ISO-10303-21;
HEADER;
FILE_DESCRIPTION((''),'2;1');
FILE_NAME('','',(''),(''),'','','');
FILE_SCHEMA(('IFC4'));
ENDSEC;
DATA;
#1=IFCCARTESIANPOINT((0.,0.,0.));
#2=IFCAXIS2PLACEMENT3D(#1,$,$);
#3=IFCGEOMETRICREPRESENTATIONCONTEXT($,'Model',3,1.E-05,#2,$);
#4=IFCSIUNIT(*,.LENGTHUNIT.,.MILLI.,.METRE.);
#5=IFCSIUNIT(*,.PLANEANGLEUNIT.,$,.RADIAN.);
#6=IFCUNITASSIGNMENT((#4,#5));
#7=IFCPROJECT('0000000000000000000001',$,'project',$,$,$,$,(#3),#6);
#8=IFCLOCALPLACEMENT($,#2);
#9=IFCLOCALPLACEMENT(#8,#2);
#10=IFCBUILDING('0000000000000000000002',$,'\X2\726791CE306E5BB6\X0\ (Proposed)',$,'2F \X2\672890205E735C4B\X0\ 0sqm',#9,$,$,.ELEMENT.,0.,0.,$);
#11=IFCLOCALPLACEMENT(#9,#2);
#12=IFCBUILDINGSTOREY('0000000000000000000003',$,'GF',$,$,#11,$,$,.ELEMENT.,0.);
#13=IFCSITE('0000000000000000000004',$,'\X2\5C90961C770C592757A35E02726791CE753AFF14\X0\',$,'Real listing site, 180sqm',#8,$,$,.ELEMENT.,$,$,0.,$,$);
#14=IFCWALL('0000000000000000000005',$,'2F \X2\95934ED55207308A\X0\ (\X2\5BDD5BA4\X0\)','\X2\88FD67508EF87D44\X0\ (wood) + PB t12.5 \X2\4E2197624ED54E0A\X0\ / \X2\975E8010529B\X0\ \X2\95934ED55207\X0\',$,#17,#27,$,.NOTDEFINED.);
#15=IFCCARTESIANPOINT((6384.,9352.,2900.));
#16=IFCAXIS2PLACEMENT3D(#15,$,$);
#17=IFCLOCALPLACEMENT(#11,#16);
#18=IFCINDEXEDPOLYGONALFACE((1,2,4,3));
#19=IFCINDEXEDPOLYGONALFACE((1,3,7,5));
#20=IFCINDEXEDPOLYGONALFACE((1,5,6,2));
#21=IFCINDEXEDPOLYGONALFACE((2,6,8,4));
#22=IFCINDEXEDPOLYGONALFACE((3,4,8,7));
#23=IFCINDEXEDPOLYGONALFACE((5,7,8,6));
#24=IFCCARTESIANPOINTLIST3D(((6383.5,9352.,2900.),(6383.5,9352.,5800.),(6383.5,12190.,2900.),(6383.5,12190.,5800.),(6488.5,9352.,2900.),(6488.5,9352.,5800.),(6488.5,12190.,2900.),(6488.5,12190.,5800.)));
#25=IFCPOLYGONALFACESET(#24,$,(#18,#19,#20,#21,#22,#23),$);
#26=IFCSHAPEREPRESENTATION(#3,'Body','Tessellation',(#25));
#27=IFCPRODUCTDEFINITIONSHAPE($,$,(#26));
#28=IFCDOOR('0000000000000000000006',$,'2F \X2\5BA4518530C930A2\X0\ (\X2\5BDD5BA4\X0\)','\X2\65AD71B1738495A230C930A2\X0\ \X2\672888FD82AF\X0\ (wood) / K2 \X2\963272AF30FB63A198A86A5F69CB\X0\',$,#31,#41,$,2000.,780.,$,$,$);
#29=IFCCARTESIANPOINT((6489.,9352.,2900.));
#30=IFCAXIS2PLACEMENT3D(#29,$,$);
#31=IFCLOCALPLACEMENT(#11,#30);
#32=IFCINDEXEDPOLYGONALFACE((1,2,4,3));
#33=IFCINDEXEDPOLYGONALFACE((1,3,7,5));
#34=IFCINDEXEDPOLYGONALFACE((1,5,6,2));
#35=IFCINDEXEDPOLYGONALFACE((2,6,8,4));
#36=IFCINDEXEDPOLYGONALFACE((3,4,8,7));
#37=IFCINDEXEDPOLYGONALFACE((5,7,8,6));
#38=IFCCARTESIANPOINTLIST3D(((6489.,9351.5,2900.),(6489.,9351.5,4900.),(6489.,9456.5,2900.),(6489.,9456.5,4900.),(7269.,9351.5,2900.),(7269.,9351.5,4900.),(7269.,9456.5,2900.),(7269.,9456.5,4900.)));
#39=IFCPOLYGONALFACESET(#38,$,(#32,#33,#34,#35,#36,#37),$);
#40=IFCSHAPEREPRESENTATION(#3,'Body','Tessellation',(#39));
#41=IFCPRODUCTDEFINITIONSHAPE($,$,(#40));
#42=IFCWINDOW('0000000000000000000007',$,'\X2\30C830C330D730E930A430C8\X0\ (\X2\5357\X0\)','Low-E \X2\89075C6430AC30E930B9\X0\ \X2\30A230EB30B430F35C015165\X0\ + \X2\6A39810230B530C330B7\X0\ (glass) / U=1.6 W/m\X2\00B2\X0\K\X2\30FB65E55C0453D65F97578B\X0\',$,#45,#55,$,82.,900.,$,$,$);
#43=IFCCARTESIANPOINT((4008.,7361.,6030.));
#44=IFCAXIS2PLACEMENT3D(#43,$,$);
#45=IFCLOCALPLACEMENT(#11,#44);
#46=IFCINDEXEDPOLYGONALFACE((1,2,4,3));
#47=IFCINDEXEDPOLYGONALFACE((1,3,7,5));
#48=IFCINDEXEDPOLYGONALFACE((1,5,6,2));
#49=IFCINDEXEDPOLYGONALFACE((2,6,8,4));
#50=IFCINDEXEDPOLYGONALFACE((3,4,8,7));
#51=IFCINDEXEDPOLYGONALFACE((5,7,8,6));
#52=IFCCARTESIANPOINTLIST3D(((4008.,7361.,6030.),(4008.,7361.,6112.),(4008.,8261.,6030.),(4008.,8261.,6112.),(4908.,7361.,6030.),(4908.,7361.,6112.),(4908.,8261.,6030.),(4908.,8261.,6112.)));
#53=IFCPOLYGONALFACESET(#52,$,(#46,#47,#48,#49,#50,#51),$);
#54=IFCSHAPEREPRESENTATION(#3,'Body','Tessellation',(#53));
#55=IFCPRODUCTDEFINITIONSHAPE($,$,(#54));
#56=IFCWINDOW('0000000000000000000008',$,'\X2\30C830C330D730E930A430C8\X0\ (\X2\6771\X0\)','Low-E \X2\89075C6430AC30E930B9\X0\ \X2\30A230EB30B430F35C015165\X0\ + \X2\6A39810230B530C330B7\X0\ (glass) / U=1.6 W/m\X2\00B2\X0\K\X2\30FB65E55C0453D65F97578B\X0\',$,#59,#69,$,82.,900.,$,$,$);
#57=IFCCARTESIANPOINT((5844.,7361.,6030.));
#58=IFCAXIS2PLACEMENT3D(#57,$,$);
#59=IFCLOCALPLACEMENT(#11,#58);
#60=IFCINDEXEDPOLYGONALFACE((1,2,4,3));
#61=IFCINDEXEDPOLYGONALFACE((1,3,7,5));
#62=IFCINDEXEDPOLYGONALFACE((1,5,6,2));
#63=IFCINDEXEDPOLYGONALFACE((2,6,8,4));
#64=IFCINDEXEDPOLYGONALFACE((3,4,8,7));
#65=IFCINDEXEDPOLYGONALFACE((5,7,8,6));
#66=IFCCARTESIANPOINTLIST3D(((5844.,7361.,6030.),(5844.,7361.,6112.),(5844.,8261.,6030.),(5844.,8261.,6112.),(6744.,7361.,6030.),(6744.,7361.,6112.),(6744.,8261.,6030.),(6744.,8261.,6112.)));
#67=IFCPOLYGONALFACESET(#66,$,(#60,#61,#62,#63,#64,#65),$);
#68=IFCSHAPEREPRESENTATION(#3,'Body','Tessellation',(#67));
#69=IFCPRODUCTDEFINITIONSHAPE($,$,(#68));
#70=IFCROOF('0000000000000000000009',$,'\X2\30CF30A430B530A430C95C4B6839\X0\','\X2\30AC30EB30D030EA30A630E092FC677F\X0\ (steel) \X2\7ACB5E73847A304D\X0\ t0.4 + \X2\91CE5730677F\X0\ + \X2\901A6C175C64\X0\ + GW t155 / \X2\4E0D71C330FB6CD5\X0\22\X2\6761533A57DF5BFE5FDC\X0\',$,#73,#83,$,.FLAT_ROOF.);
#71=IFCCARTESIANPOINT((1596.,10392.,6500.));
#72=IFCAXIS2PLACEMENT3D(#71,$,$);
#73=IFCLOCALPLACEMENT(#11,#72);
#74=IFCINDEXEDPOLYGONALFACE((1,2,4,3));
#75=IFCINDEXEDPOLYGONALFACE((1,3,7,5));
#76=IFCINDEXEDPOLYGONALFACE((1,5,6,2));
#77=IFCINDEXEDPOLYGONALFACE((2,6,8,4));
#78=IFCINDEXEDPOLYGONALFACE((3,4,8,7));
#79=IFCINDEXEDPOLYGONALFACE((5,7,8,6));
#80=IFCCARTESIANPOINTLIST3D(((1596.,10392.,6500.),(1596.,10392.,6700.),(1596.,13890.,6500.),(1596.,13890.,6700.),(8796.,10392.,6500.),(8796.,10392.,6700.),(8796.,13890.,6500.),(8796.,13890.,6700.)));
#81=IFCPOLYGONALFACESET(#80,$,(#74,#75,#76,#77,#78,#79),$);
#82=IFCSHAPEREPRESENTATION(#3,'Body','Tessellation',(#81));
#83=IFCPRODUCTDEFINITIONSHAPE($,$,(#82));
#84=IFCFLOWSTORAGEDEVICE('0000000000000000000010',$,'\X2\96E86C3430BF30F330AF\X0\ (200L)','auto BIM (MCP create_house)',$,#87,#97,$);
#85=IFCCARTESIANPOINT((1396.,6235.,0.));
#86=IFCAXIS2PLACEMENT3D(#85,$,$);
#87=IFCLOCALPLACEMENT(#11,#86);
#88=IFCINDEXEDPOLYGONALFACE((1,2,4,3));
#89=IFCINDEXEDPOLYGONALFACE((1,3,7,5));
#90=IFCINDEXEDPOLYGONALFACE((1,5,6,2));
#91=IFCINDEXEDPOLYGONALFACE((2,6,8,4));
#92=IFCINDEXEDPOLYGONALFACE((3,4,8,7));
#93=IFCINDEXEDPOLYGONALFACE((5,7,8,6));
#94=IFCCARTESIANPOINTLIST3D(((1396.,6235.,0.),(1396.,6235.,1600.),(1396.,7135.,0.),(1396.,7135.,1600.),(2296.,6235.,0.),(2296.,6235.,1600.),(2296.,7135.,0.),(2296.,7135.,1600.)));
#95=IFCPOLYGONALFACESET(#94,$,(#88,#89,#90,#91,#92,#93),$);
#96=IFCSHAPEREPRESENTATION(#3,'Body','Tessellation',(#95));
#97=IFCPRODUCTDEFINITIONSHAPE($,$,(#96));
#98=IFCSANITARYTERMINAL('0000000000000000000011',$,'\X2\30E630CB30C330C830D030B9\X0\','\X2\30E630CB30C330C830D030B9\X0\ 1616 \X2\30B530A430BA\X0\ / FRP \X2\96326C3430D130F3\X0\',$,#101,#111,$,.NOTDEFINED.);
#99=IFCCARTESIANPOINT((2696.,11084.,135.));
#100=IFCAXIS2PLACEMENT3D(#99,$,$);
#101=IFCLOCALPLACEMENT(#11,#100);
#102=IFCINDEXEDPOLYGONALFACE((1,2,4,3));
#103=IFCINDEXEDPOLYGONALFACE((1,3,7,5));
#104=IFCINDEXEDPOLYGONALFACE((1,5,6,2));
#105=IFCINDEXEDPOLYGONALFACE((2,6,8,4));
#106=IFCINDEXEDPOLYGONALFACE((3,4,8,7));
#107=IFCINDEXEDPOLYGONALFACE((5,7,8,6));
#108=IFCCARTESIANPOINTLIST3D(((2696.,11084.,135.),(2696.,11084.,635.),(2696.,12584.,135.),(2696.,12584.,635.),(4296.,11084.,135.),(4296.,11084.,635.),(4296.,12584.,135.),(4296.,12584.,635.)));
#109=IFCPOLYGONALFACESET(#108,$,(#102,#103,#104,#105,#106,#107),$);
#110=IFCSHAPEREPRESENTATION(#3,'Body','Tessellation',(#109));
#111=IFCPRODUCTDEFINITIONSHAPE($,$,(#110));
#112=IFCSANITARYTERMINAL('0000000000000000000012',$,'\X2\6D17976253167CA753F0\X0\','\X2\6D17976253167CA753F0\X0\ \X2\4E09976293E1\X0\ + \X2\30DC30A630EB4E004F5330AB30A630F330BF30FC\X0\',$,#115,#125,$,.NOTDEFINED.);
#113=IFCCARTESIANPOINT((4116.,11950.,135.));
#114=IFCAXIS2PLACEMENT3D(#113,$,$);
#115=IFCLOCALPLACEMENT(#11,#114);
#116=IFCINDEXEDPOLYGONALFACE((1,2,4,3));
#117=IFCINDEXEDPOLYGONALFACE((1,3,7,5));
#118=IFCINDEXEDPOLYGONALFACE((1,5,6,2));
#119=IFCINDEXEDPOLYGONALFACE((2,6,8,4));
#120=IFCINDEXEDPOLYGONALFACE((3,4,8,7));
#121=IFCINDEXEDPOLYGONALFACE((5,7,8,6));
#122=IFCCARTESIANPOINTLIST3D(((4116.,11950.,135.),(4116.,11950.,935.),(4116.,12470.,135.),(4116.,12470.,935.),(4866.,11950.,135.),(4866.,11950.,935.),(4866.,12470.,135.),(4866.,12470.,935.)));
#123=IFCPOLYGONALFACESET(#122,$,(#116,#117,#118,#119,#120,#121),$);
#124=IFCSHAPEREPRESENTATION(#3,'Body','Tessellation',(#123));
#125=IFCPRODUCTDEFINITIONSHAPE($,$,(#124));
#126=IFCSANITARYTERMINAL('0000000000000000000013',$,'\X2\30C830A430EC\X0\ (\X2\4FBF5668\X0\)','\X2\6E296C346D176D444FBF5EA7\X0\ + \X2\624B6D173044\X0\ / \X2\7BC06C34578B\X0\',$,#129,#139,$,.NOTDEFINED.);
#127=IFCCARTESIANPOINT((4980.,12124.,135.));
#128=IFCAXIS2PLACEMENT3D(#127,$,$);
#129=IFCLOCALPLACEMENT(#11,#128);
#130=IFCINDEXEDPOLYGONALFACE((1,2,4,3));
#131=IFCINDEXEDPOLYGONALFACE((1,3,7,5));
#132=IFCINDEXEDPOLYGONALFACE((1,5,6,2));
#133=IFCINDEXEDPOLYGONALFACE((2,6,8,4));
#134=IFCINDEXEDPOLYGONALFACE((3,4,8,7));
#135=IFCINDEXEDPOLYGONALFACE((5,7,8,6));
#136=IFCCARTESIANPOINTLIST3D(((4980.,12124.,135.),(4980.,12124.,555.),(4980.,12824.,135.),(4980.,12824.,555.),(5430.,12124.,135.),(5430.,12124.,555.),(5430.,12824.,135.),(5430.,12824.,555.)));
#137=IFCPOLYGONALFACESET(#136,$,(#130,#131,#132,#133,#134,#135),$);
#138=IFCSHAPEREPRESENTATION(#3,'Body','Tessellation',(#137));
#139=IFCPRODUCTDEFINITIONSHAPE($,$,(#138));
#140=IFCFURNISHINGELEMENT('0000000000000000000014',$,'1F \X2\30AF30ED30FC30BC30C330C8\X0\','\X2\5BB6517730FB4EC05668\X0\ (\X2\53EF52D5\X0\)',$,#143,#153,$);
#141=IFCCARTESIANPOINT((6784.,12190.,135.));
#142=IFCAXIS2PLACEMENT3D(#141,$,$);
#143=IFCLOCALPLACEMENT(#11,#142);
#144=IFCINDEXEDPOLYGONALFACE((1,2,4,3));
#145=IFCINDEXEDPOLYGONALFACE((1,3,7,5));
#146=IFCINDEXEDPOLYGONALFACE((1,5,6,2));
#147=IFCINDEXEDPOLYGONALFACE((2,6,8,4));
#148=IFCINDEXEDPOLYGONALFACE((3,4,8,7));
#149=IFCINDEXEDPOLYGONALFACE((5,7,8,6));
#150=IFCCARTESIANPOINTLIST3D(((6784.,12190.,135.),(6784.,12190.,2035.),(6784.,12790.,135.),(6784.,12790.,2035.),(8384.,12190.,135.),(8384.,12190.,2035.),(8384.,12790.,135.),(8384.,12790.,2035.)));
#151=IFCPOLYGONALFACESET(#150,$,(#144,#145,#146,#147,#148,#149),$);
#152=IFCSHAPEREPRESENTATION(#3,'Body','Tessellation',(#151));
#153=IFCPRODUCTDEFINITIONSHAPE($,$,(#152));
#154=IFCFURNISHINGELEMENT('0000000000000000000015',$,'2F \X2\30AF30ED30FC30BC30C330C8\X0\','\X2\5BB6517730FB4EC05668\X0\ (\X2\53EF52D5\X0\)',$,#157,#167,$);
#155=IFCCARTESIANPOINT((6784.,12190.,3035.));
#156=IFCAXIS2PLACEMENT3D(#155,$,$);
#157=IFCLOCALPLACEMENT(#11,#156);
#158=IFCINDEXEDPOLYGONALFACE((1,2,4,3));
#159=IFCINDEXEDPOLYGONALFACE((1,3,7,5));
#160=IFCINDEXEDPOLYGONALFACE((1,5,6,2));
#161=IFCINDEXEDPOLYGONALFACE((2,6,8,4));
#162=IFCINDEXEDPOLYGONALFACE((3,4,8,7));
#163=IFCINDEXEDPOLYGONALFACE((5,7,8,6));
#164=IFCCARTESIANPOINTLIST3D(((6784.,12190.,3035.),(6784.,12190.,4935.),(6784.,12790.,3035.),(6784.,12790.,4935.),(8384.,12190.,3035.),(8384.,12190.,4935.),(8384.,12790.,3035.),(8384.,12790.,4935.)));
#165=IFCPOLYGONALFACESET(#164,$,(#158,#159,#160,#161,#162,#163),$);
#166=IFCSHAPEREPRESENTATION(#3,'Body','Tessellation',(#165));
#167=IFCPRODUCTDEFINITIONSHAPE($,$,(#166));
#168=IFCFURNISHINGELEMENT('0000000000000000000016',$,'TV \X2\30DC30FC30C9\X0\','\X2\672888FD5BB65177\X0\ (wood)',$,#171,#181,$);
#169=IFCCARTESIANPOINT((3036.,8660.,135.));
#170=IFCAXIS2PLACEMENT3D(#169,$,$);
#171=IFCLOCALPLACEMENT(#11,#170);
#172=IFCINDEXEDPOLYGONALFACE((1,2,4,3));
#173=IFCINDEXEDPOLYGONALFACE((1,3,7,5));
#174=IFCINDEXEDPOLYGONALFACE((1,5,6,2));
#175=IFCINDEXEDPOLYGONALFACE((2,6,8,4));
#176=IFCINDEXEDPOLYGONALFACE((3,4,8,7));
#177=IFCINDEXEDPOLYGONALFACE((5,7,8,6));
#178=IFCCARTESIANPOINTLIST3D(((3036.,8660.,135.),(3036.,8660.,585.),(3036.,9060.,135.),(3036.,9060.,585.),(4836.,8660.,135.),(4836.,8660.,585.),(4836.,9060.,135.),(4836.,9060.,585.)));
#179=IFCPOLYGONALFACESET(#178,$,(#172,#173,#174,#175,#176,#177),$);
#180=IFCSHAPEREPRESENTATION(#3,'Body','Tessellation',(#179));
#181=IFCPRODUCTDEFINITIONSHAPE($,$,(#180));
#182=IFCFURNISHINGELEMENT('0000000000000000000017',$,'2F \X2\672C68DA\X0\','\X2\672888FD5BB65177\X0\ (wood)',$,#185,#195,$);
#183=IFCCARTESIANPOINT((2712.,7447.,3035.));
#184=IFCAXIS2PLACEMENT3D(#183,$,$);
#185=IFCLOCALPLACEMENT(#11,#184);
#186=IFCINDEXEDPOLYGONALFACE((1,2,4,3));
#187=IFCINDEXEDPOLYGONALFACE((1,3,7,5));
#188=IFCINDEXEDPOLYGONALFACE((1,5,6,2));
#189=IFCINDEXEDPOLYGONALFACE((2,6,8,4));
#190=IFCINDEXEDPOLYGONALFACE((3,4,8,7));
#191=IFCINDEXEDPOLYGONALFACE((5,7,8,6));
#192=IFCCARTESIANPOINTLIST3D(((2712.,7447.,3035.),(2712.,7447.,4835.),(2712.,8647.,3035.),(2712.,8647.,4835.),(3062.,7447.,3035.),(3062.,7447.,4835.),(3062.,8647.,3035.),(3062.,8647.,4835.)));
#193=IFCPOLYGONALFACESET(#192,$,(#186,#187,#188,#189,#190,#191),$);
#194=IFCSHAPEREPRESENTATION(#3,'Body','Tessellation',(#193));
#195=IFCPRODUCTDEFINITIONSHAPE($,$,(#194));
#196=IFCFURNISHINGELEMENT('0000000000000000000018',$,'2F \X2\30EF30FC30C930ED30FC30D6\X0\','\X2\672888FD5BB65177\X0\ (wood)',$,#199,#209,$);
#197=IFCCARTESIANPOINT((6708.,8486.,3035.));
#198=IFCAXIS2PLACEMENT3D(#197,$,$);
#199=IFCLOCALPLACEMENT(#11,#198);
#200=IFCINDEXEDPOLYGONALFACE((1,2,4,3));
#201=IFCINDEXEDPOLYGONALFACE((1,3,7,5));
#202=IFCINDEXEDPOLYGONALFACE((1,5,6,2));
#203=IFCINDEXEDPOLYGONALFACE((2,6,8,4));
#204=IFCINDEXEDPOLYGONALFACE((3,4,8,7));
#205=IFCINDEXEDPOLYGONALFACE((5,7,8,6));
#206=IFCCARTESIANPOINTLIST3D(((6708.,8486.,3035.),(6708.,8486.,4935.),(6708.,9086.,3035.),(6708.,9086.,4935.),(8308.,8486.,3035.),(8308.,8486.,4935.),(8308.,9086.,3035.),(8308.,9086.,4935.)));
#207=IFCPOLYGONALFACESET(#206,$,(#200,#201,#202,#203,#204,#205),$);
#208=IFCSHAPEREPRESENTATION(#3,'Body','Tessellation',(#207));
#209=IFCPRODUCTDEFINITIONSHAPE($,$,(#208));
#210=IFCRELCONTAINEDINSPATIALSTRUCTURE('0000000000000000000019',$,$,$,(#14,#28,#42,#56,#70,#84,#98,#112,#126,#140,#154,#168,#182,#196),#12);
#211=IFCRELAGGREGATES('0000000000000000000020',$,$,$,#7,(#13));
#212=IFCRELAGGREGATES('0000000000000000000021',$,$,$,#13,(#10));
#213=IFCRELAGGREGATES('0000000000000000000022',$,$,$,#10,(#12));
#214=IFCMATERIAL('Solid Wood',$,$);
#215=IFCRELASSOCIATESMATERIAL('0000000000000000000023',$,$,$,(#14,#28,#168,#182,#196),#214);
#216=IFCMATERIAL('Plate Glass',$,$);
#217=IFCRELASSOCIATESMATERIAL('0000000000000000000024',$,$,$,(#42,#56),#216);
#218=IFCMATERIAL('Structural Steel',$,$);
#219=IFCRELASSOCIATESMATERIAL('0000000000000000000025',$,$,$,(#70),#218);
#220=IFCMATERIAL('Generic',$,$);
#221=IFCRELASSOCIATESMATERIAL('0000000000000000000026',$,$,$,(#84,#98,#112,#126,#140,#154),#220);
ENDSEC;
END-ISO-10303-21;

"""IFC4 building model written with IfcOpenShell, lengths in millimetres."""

from ifc_helpers import new_model, si_unit, frame, frame_2d, origin, place, context, project, spatial, rectangle, extrude, material, element, save


model = new_model("IFC4")

# Units and contexts
model_context = context("Model", 3, precision=1e-05, world=origin())
ifc_project = project(units=[si_unit("LENGTHUNIT", "METRE", prefix="MILLI"), si_unit("PLANEANGLEUNIT", "RADIAN")], contexts=[model_context])

# Site, building, storey
site_placement = place(None, origin())
site = spatial("IfcSite", under=ifc_project, at=site_placement, Name="岐阜県大垣市牧野町４", ObjectType="Real listing site, 180sqm", CompositionType="ELEMENT", RefElevation=0.0)
building_placement = place(site_placement, origin())
building = spatial("IfcBuilding", under=site, at=building_placement, Name="牧野の家 (Proposed)", ObjectType="2F 木造平屋 0sqm", CompositionType="ELEMENT", ElevationOfRefHeight=0.0, ElevationOfTerrain=0.0)
storey_placement = place(building_placement, origin())
storey = spatial("IfcBuildingStorey", under=building, at=storey_placement, Name="GF", CompositionType="ELEMENT", Elevation=0.0)

# Shared definitions
ifc_material_1 = material(Name="Solid Wood")
ifc_material_2 = material(Name="Plate Glass")

# Wall
wall_1_placement = place(storey_placement, frame((6384.0, 9352.0, 2900.0)))
element("IfcWall", 1, at=wall_1_placement, inside=storey, material=ifc_material_1, Name="2F 間仕切り (寝室)", Description="製材軸組 (wood) + PB t12.5 両面仕上 / 非耐力 間仕切", PredefinedType="NOTDEFINED", context=model_context, shape_type="SweptSolid", body=[
    extrude(rectangle(XDim=105.0, YDim=2838.0, at=frame_2d((52.0, 1419.0))), frame((6384.0, 9352.0, 2900.0)), (0.0, 0.0, 1.0), 2900.0),
])

# Door
door_1_placement = place(storey_placement, frame((6489.0, 9352.0, 2900.0)))
element("IfcDoor", 2, at=door_1_placement, inside=storey, material=ifc_material_1, Name="2F 室内ドア (寝室)", Description="断熱玄関ドア 木製芯 (wood) / K2 防犯・採風機構", OverallHeight=2000.0, OverallWidth=780.0, context=model_context, shape_type="SweptSolid", body=[
    extrude(rectangle(XDim=780.0, YDim=105.0, at=frame_2d((390.0, 52.0))), frame((6489.0, 9352.0, 2900.0)), (0.0, 0.0, 1.0), 2000.0),
])

# Windows
window_1_placement = place(storey_placement, frame((4008.0, 7361.0, 6030.0)))
element("IfcWindow", 3, at=window_1_placement, inside=storey, material=ifc_material_2, Name="トップライト (南)", Description="Low-E 複層ガラス アルゴン封入 + 樹脂サッシ (glass) / U=1.6 W/m²K・日射取得型", OverallHeight=82.0, OverallWidth=900.0, context=model_context, shape_type="SweptSolid", body=[
    extrude(rectangle(XDim=900.0, YDim=900.0, at=frame_2d((450.0, 450.0))), frame((4008.0, 7361.0, 6030.0)), (0.0, 0.0, 1.0), 82.0),
])
window_2_placement = place(storey_placement, frame((5844.0, 7361.0, 6030.0)))
element("IfcWindow", 4, at=window_2_placement, inside=storey, material=ifc_material_2, Name="トップライト (東)", Description="Low-E 複層ガラス アルゴン封入 + 樹脂サッシ (glass) / U=1.6 W/m²K・日射取得型", OverallHeight=82.0, OverallWidth=900.0, context=model_context, shape_type="SweptSolid", body=[
    extrude(rectangle(XDim=900.0, YDim=900.0, at=frame_2d((450.0, 450.0))), frame((5844.0, 7361.0, 6030.0)), (0.0, 0.0, 1.0), 82.0),
])

# Roof
ifc_material_3 = material(Name="Structural Steel")
roof_placement = place(storey_placement, frame((1596.0, 10392.0, 6500.0)))
element("IfcRoof", 5, at=roof_placement, inside=storey, material=ifc_material_3, Name="ハイサイド屋根", Description="ガルバリウム鋼板 (steel) 立平葺き t0.4 + 野地板 + 通気層 + GW t155 / 不燃・法22条区域対応", PredefinedType="FLAT_ROOF", context=model_context, shape_type="SweptSolid", body=[
    extrude(rectangle(XDim=7200.0, YDim=3498.0, at=frame_2d((3600.0, 1749.0))), frame((1596.0, 10392.0, 6500.0)), (0.0, 0.0, 1.0), 200.0),
])

# Flow storage device
ifc_material_4 = material(Name="Generic")
flow_storage_device_placement = place(storey_placement, frame((1396.0, 6235.0, 0.0)))
element("IfcFlowStorageDevice", 6, at=flow_storage_device_placement, inside=storey, material=ifc_material_4, Name="雨水タンク (200L)", Description="auto BIM (MCP create_house)", context=model_context, shape_type="SweptSolid", body=[
    extrude(rectangle(XDim=900.0, YDim=900.0, at=frame_2d((450.0, 450.0))), frame((1396.0, 6235.0, 0.0)), (0.0, 0.0, 1.0), 1600.0),
])

# Sanitary terminals
sanitary_terminal_1_placement = place(storey_placement, frame((2696.0, 11084.0, 135.0)))
element("IfcSanitaryTerminal", 7, at=sanitary_terminal_1_placement, inside=storey, material=ifc_material_4, Name="ユニットバス", Description="ユニットバス 1616 サイズ / FRP 防水パン", PredefinedType="NOTDEFINED", context=model_context, shape_type="SweptSolid", body=[
    extrude(rectangle(XDim=1600.0, YDim=1500.0, at=frame_2d((800.0, 750.0))), frame((2696.0, 11084.0, 135.0)), (0.0, 0.0, 1.0), 500.0),
])
sanitary_terminal_2_placement = place(storey_placement, frame((4116.0, 11950.0, 135.0)))
element("IfcSanitaryTerminal", 8, at=sanitary_terminal_2_placement, inside=storey, material=ifc_material_4, Name="洗面化粧台", Description="洗面化粧台 三面鏡 + ボウル一体カウンター", PredefinedType="NOTDEFINED", context=model_context, shape_type="SweptSolid", body=[
    extrude(rectangle(XDim=750.0, YDim=520.0, at=frame_2d((375.0, 260.0))), frame((4116.0, 11950.0, 135.0)), (0.0, 0.0, 1.0), 800.0),
])
sanitary_terminal_3_placement = place(storey_placement, frame((4980.0, 12124.0, 135.0)))
element("IfcSanitaryTerminal", 9, at=sanitary_terminal_3_placement, inside=storey, material=ifc_material_4, Name="トイレ (便器)", Description="温水洗浄便座 + 手洗い / 節水型", PredefinedType="NOTDEFINED", context=model_context, shape_type="SweptSolid", body=[
    extrude(rectangle(XDim=450.0, YDim=700.0, at=frame_2d((225.0, 350.0))), frame((4980.0, 12124.0, 135.0)), (0.0, 0.0, 1.0), 420.0),
])

# Furnishing elements
furnishing_1_placement = place(storey_placement, frame((6784.0, 12190.0, 135.0)))
element("IfcFurnishingElement", 10, at=furnishing_1_placement, inside=storey, material=ifc_material_4, Name="1F クローゼット", Description="家具・什器 (可動)", context=model_context, shape_type="SweptSolid", body=[
    extrude(rectangle(XDim=1600.0, YDim=600.0, at=frame_2d((800.0, 300.0))), frame((6784.0, 12190.0, 135.0)), (0.0, 0.0, 1.0), 1900.0),
])
furnishing_2_placement = place(storey_placement, frame((6784.0, 12190.0, 3035.0)))
element("IfcFurnishingElement", 11, at=furnishing_2_placement, inside=storey, material=ifc_material_4, Name="2F クローゼット", Description="家具・什器 (可動)", context=model_context, shape_type="SweptSolid", body=[
    extrude(rectangle(XDim=1600.0, YDim=600.0, at=frame_2d((800.0, 300.0))), frame((6784.0, 12190.0, 3035.0)), (0.0, 0.0, 1.0), 1900.0),
])
furnishing_3_placement = place(storey_placement, frame((3036.0, 8660.0, 135.0)))
element("IfcFurnishingElement", 12, at=furnishing_3_placement, inside=storey, material=ifc_material_1, Name="TV ボード", Description="木製家具 (wood)", context=model_context, shape_type="SweptSolid", body=[
    extrude(rectangle(XDim=1800.0, YDim=400.0, at=frame_2d((900.0, 200.0))), frame((3036.0, 8660.0, 135.0)), (0.0, 0.0, 1.0), 450.0),
])
furnishing_4_placement = place(storey_placement, frame((2712.0, 7447.0, 3035.0)))
element("IfcFurnishingElement", 13, at=furnishing_4_placement, inside=storey, material=ifc_material_1, Name="2F 本棚", Description="木製家具 (wood)", context=model_context, shape_type="SweptSolid", body=[
    extrude(rectangle(XDim=350.0, YDim=1200.0, at=frame_2d((175.0, 600.0))), frame((2712.0, 7447.0, 3035.0)), (0.0, 0.0, 1.0), 1800.0),
])
furnishing_5_placement = place(storey_placement, frame((6708.0, 8486.0, 3035.0)))
element("IfcFurnishingElement", 14, at=furnishing_5_placement, inside=storey, material=ifc_material_1, Name="2F ワードローブ", Description="木製家具 (wood)", context=model_context, shape_type="SweptSolid", body=[
    extrude(rectangle(XDim=1600.0, YDim=600.0, at=frame_2d((800.0, 300.0))), frame((6708.0, 8486.0, 3035.0)), (0.0, 0.0, 1.0), 1900.0),
])

save(model, "model.ifc")
